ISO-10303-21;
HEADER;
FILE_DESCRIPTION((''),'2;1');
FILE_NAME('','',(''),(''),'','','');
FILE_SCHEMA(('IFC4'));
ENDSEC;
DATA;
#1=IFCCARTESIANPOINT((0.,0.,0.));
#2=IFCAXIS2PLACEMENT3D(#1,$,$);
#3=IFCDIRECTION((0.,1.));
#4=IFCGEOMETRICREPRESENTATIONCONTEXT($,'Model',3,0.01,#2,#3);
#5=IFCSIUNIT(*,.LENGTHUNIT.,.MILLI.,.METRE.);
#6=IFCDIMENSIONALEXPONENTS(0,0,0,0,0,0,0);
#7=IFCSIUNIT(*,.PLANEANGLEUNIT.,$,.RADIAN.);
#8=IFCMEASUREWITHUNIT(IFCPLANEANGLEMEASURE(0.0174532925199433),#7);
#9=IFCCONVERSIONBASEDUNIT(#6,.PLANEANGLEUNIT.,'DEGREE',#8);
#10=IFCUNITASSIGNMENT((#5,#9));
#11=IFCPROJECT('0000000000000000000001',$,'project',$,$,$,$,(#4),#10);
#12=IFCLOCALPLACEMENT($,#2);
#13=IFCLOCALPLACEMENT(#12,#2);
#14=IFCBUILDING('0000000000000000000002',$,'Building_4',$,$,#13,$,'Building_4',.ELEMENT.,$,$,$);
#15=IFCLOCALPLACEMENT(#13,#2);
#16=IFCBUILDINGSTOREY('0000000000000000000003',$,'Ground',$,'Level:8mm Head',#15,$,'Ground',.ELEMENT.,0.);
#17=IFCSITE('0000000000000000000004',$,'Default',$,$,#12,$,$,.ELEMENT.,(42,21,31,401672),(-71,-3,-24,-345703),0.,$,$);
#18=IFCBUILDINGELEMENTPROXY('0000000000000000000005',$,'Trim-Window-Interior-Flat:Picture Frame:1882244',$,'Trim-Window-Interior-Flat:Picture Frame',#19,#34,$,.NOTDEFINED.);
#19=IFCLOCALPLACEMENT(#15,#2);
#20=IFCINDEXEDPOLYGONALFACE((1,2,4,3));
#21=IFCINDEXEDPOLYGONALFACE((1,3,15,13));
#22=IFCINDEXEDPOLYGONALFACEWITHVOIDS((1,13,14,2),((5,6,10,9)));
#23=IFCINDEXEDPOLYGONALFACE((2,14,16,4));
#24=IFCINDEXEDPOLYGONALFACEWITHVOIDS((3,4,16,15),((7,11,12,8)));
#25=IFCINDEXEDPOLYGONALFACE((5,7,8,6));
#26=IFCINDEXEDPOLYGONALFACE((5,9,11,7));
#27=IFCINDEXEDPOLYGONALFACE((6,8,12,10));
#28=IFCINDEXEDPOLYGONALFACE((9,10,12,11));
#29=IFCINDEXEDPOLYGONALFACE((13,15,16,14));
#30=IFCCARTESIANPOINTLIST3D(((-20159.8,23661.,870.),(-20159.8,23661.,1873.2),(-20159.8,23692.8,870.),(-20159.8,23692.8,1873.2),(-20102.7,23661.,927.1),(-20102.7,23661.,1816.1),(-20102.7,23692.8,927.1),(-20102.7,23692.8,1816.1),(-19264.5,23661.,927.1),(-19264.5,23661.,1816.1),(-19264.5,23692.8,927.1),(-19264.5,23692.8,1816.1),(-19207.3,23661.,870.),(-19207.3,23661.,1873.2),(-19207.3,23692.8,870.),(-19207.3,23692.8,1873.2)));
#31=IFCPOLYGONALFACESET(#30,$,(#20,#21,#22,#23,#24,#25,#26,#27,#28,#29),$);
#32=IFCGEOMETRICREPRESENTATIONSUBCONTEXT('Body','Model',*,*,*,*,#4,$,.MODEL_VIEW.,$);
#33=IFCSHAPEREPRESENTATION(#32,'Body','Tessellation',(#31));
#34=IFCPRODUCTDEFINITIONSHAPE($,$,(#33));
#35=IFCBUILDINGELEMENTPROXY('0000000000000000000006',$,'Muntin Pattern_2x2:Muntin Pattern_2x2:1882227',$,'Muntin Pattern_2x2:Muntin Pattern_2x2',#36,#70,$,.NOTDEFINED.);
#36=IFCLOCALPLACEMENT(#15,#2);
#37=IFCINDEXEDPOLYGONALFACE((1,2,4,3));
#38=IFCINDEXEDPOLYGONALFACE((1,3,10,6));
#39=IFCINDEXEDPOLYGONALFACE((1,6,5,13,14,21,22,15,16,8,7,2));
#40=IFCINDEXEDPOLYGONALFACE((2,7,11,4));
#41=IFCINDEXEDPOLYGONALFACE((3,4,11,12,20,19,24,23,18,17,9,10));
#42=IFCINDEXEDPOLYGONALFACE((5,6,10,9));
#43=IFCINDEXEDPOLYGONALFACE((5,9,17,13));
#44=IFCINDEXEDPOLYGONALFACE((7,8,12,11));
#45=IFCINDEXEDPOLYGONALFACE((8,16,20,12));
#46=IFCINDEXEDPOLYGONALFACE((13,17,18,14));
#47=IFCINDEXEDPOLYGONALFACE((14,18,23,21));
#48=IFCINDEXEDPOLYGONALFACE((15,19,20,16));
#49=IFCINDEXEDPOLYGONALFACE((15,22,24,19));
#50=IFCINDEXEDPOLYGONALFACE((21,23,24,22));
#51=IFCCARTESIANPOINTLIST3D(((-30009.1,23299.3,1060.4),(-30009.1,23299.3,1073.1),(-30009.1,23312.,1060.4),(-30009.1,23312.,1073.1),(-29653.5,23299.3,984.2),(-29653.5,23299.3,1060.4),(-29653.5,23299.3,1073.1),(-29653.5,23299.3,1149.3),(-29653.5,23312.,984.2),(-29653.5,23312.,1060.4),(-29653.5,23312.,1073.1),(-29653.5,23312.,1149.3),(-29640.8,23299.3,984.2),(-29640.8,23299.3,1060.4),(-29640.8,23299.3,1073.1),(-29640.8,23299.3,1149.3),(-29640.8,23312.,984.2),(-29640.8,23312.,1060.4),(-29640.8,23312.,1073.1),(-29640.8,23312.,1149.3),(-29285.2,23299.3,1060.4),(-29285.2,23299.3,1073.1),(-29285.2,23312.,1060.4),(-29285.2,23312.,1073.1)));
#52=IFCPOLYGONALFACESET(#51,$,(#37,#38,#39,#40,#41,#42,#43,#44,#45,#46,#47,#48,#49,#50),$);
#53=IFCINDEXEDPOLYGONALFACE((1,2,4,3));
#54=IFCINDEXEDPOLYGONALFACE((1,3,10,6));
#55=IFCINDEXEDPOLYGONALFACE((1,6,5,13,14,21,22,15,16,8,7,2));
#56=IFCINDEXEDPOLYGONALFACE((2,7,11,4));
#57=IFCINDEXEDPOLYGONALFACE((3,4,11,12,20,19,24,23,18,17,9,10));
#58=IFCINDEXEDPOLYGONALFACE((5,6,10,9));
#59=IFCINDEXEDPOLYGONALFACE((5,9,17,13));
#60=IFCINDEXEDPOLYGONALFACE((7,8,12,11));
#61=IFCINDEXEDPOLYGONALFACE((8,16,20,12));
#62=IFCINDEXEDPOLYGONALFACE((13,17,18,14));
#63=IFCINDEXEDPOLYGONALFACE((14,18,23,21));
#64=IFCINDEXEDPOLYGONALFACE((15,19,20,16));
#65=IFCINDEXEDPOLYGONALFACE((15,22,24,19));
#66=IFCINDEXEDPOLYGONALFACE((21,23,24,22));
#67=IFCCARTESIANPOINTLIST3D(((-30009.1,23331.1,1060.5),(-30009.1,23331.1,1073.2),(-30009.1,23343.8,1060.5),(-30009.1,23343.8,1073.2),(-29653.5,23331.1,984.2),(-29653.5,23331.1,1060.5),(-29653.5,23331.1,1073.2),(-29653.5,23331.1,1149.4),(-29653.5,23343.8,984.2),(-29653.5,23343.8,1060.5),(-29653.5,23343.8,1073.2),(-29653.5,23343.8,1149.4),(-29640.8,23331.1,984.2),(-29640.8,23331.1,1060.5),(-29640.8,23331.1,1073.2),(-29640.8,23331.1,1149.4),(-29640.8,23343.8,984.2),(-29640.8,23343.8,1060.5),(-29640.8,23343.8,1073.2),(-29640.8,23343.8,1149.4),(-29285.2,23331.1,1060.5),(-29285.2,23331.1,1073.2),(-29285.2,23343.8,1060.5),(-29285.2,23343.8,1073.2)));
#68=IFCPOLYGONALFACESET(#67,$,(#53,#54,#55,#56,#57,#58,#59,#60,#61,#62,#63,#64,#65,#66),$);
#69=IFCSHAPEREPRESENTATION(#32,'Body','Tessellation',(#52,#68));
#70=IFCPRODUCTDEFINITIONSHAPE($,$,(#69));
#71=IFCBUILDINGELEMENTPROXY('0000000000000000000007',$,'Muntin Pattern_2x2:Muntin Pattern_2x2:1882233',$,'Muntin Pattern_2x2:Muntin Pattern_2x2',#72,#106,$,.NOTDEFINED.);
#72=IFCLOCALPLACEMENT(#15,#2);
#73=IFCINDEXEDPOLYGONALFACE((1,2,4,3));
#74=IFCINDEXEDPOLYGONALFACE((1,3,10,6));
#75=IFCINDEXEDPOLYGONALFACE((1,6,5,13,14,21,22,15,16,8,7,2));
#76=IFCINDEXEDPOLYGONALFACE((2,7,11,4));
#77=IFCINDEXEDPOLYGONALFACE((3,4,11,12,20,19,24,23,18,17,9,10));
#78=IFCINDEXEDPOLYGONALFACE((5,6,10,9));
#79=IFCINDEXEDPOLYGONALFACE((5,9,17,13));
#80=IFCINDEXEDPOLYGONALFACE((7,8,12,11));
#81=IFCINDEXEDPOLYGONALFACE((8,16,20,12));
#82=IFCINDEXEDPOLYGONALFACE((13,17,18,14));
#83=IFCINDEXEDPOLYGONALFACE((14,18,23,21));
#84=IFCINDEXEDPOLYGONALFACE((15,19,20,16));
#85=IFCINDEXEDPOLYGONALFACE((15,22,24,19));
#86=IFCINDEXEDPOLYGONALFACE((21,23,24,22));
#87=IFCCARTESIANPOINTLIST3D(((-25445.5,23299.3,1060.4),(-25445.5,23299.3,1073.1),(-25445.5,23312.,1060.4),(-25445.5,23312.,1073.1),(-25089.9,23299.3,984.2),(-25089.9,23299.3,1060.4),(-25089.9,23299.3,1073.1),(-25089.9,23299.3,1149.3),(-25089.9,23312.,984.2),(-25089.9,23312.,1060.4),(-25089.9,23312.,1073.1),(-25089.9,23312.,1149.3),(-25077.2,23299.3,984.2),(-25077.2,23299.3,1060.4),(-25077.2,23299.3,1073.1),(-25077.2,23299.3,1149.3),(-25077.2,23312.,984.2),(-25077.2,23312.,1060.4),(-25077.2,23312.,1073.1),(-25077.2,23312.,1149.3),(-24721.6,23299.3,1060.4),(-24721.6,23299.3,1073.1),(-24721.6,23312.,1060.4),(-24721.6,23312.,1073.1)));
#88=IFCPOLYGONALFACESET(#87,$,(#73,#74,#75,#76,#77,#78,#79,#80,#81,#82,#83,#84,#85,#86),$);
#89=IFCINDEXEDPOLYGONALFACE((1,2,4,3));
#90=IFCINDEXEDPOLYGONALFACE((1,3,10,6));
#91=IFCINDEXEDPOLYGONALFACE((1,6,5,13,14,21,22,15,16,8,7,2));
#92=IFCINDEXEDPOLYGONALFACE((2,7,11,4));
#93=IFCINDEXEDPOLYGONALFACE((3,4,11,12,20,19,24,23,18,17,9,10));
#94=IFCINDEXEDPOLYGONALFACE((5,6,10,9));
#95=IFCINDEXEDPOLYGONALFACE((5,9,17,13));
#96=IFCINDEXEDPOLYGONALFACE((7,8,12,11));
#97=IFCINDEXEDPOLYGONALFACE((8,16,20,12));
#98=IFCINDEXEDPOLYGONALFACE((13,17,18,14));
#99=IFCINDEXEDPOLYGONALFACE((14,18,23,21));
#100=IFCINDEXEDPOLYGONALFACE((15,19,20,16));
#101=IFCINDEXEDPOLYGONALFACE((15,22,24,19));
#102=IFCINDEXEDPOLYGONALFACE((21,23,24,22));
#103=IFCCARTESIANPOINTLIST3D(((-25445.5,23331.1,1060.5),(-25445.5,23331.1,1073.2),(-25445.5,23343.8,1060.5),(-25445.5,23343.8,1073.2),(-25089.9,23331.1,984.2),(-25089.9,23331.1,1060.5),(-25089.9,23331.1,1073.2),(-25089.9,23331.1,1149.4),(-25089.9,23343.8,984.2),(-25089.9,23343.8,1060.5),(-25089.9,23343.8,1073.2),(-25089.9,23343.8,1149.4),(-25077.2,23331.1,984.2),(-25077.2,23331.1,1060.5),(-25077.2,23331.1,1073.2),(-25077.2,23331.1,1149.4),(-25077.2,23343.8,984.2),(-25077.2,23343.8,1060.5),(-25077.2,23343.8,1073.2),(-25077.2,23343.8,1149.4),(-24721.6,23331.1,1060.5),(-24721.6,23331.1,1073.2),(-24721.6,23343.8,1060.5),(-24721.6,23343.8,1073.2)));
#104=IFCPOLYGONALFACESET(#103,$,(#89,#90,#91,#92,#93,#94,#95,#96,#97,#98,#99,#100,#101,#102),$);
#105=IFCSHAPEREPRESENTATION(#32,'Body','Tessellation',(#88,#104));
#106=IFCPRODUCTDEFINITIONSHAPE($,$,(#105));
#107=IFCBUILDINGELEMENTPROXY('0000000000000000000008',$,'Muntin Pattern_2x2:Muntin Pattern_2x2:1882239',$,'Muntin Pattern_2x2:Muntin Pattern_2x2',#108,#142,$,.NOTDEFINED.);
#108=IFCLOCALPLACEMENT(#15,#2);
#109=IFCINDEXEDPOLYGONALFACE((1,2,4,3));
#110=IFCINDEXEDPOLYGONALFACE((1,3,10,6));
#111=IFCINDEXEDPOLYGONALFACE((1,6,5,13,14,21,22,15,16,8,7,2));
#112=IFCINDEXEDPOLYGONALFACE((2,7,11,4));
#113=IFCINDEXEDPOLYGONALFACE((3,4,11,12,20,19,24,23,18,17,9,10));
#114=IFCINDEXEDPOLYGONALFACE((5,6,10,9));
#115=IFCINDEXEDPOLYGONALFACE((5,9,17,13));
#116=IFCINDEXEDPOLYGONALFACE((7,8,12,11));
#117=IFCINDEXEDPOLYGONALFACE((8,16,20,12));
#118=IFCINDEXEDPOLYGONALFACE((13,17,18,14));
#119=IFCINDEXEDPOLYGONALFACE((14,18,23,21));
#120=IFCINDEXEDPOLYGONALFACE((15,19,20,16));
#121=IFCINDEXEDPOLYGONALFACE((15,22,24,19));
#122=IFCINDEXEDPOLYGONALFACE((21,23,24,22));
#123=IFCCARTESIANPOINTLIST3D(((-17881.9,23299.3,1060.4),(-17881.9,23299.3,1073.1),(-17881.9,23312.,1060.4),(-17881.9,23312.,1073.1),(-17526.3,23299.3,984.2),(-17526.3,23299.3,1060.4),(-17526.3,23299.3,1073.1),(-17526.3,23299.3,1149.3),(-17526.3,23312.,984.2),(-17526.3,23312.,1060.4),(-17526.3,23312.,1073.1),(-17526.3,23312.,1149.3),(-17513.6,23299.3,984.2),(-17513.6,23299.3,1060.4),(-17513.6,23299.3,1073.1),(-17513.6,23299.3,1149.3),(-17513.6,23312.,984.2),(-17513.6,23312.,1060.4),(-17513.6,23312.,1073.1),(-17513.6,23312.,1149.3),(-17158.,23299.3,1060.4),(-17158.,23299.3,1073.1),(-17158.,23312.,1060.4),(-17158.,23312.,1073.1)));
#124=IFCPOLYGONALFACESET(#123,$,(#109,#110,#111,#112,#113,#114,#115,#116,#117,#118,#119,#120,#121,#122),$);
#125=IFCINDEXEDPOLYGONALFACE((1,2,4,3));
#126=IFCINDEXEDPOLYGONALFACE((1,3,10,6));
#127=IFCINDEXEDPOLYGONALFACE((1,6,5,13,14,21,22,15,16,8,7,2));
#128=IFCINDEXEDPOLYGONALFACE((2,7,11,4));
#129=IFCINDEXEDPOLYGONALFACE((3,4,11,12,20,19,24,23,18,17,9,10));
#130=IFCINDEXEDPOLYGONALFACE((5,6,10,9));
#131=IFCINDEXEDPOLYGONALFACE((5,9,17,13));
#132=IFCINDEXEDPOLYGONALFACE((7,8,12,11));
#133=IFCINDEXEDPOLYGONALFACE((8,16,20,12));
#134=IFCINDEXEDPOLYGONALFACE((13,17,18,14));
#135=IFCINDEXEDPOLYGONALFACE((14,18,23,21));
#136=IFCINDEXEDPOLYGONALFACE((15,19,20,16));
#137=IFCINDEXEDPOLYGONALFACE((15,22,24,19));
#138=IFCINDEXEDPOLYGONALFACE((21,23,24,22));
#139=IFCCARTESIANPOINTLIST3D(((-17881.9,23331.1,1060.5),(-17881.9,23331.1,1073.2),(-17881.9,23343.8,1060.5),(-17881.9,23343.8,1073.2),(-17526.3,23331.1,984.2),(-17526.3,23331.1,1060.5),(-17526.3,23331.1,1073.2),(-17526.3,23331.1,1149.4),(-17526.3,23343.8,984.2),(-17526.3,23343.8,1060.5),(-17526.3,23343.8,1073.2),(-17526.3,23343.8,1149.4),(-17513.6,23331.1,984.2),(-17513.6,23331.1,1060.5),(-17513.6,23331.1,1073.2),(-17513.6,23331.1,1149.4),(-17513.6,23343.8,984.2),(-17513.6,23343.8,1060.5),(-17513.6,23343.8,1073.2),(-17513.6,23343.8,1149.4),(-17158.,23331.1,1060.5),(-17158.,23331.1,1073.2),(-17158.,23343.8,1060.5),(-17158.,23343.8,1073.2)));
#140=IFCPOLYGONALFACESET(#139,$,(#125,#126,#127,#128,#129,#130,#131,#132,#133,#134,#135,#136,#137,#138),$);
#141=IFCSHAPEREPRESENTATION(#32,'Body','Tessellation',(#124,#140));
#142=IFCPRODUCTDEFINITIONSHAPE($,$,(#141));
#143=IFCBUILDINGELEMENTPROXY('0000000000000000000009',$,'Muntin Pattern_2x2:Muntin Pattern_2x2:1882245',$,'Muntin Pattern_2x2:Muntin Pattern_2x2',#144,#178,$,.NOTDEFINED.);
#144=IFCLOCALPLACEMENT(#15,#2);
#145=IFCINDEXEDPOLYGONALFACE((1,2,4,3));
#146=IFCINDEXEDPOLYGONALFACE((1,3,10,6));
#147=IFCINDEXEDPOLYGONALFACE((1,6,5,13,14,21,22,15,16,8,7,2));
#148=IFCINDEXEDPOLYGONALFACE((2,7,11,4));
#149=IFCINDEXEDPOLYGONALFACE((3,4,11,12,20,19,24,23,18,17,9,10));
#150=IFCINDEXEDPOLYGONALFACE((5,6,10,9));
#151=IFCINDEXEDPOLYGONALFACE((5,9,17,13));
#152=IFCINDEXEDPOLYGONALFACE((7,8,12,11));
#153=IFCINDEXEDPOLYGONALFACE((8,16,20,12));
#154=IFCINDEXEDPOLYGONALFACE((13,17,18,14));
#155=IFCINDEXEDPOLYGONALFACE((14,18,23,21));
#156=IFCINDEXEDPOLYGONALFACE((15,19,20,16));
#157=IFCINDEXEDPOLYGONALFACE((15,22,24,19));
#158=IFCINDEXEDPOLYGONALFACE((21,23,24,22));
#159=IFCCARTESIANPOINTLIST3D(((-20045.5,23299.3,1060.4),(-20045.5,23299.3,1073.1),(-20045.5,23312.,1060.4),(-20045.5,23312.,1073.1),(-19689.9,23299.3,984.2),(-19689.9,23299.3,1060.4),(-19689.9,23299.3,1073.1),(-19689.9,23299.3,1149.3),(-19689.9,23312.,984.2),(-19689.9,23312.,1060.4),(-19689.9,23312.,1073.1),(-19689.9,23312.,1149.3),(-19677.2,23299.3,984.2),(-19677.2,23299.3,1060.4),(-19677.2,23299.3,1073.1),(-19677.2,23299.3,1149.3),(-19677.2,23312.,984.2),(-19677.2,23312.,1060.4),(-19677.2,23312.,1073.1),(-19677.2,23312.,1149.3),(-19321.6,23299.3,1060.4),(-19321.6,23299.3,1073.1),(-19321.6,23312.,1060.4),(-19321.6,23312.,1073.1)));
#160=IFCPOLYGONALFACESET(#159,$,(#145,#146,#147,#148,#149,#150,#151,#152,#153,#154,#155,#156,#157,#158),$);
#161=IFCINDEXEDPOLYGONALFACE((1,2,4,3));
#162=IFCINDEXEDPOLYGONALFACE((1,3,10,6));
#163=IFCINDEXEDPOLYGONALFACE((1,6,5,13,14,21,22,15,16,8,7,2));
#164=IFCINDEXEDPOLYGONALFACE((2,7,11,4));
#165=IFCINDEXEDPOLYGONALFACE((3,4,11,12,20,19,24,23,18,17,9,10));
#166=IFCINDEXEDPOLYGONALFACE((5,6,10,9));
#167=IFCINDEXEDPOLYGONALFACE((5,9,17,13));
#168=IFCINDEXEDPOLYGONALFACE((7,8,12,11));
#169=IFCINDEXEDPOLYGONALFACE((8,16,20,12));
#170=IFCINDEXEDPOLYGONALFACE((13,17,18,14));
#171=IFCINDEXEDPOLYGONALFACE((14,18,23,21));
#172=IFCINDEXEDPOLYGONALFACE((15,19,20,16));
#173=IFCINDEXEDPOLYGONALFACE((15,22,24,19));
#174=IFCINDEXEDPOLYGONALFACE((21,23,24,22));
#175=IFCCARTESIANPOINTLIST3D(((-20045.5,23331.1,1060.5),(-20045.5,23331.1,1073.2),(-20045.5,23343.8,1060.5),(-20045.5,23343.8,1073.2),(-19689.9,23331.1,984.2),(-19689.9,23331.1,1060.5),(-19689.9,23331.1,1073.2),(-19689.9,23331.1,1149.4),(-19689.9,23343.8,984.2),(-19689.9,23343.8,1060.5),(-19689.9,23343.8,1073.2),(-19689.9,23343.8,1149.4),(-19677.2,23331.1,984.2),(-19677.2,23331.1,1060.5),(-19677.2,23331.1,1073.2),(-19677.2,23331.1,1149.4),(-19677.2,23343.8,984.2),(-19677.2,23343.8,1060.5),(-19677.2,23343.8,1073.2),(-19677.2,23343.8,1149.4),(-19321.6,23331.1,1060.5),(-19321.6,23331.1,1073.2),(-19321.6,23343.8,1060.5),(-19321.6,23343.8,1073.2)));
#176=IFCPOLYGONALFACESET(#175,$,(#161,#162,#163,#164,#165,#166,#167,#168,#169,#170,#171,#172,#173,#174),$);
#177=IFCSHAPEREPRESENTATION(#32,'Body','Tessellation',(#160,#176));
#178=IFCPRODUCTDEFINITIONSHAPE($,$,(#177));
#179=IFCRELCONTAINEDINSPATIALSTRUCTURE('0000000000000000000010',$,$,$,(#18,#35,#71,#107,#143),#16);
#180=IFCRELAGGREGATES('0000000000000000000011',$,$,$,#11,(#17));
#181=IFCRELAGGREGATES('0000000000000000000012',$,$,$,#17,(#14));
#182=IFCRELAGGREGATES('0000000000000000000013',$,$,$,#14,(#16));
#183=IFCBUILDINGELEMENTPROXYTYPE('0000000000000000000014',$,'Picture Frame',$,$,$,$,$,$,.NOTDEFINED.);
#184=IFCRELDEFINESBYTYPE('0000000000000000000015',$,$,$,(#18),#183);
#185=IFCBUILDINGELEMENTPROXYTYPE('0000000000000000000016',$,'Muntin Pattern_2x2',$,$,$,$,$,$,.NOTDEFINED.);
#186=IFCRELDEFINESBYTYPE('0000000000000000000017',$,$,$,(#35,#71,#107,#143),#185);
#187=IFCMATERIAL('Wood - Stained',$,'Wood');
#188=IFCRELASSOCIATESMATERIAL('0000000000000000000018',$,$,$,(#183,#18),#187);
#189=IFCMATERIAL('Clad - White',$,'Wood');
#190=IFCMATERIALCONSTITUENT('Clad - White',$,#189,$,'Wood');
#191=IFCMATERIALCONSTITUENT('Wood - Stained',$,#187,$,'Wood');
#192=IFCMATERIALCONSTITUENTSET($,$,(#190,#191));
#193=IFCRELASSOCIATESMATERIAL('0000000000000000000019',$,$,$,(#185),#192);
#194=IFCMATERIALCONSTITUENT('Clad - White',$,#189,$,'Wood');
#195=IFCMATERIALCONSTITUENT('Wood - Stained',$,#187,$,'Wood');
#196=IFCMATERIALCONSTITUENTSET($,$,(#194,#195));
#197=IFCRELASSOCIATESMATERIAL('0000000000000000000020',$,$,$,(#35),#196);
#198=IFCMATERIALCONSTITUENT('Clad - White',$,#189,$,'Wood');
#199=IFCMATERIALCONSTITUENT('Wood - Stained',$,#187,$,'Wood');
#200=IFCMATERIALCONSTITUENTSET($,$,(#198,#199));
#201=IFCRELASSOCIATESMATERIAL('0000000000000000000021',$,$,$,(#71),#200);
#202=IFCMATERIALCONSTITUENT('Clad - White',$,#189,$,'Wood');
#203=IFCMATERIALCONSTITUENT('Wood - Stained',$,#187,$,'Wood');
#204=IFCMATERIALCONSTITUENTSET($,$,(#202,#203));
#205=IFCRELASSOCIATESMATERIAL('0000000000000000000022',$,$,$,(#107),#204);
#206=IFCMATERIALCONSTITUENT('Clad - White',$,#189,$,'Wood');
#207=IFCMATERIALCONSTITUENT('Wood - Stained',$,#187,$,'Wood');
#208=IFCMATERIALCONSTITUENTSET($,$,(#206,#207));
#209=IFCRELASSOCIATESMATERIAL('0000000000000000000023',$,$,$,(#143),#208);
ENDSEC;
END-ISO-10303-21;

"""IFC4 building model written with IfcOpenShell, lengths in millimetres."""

from ifc_helpers import new_model, entity, si_unit, converted_unit, direction, frame, origin, place, context, subcontext, project, spatial, indexed_curve, outline, extrude, source, transform, mapped, material, constituent, constituent_set, type_object, type_shapes, element, save


model = new_model("IFC4")

# Units and contexts
model_context = context("Model", 3, precision=0.01, world=origin(), true_north=direction((0.0, 1.0)))
body_context = subcontext(model_context, "Body", "Model", "MODEL_VIEW")
ifc_project = project(units=[si_unit("LENGTHUNIT", "METRE", prefix="MILLI"), converted_unit("PLANEANGLEUNIT", "DEGREE", entity("IfcPlaneAngleMeasure", 0.0174532925199433), si_unit("PLANEANGLEUNIT", "RADIAN"), dimensions=[0, 0, 0, 0, 0, 0, 0])], contexts=[model_context])

# Site, building, storey
site_placement = place(None, origin())
site = spatial("IfcSite", under=ifc_project, at=site_placement, Name="Default", CompositionType="ELEMENT", RefLatitude=(42, 21, 31, 401672), RefLongitude=(-71, -3, -24, -345703), RefElevation=0.0)
building_placement = place(site_placement, origin())
building = spatial("IfcBuilding", under=site, at=building_placement, Name="Building_4", LongName="Building_4", CompositionType="ELEMENT")
storey_placement = place(building_placement, origin())
storey = spatial("IfcBuildingStorey", under=building, at=storey_placement, Name="Ground", ObjectType="Level:8mm Head", LongName="Ground", CompositionType="ELEMENT", Elevation=0.0)

# Shared definitions
ifc_material_1 = material(Name="Clad - White", Category="Wood")
ifc_material_2 = material(Name="Wood - Stained", Category="Wood")

# Building element proxies
building_element_proxy_type_1 = type_object("IfcBuildingElementProxyType", Name="Picture Frame", PredefinedType="NOTDEFINED", material=ifc_material_2)
shared_shape_1 = source(origin(), body_context, "Body", "SweptSolid", [
    extrude(outline(indexed_curve([(-476.2, -501.6), (476.2, -501.6), (476.2, 501.6), (-476.2, 501.6), (-476.2, -501.6)], self_intersect=False), holes=[indexed_curve([(-419.1, -444.5), (-419.1, 444.5), (419.1, 444.5), (419.1, -444.5), (-419.1, -444.5)], self_intersect=False)]), frame((0.0, -457.2, 0.0), z_axis=(0.0, 0.0, 1.0), x_axis=(-1.0, 0.0, 0.0)), (0.0, 0.0, 1.0), 31.8),
])
type_shapes(building_element_proxy_type_1, [shared_shape_1])
for number, where, z_axis, x_axis, name in (
    (1, (-19683.6, 23661.0, 1828.8), (0.0, 1.0, 0.0), (-1.0, 0.0, 0.0), "Trim-Window-Interior-Flat:Picture Frame:1882244"),
):
    element("IfcBuildingElementProxy", number, at=place(storey_placement, frame(where, z_axis=z_axis, x_axis=x_axis)), inside=storey, type_object=building_element_proxy_type_1, material=ifc_material_2, Name=name, ObjectType="Trim-Window-Interior-Flat:Picture Frame", PredefinedType="NOTDEFINED", context=body_context, shape_type="MappedRepresentation", body=[
        mapped(shared_shape_1, transform((0.0, 0.0, 0.0), scale=1.0)),
    ])
ifc_constituent_1 = constituent(ifc_material_1, Name="Clad - White", Category="Wood")
ifc_constituent_2 = constituent(ifc_material_2, Name="Wood - Stained", Category="Wood")
ifc_constituent_set_1 = constituent_set(constituents=[ifc_constituent_1, ifc_constituent_2])
ifc_constituent_3 = constituent(ifc_material_1, Name="Clad - White", Category="Wood")
ifc_constituent_4 = constituent(ifc_material_2, Name="Wood - Stained", Category="Wood")
ifc_constituent_set_2 = constituent_set(constituents=[ifc_constituent_3, ifc_constituent_4])
building_element_proxy_type_2 = type_object("IfcBuildingElementProxyType", Name="Muntin Pattern_2x2", PredefinedType="NOTDEFINED", material=ifc_constituent_set_2)
shared_shape_2 = source(origin(), body_context, "Body", "SweptSolid", [
    extrude(outline(indexed_curve([(6.4, -6.4), (82.5, -6.4), (82.5, 6.3), (6.4, 6.3), (6.4, 362.0), (-6.3, 362.0), (-6.3, 6.3), (-82.6, 6.3), (-82.6, -6.4), (-6.3, -6.4), (-6.3, -361.9), (6.4, -361.9), (6.4, -6.4)], self_intersect=False)), frame((0.0, -22.2, 82.5), z_axis=(0.0, 1.0, 0.0), x_axis=(0.0, 0.0, 1.0)), (0.0, 0.0, 1.0), 12.7),
    extrude(outline(indexed_curve([(6.4, -6.4), (82.6, -6.4), (82.6, 6.3), (6.4, 6.3), (6.4, 362.0), (-6.3, 362.0), (-6.3, 6.3), (-82.6, 6.3), (-82.6, -6.4), (-6.3, -6.4), (-6.3, -361.9), (6.4, -361.9), (6.4, -6.4)], self_intersect=False)), frame((0.0, 9.5, 82.6), z_axis=(0.0, 1.0, 0.0), x_axis=(0.0, 0.0, 1.0)), (0.0, 0.0, 1.0), 12.7),
])
type_shapes(building_element_proxy_type_2, [shared_shape_2])
proxy_1_placement = place(storey_placement, frame((-29647.2, 23321.5, 984.2)))
element("IfcBuildingElementProxy", 2, at=proxy_1_placement, inside=storey, type_object=building_element_proxy_type_2, material=ifc_constituent_set_1, Name="Muntin Pattern_2x2:Muntin Pattern_2x2:1882227", ObjectType="Muntin Pattern_2x2:Muntin Pattern_2x2", PredefinedType="NOTDEFINED", context=body_context, shape_type="MappedRepresentation", body=[
    mapped(shared_shape_2, transform((0.0, 0.0, 0.0), scale=1.0)),
])
ifc_constituent_5 = constituent(ifc_material_1, Name="Clad - White", Category="Wood")
ifc_constituent_6 = constituent(ifc_material_2, Name="Wood - Stained", Category="Wood")
ifc_constituent_set_3 = constituent_set(constituents=[ifc_constituent_5, ifc_constituent_6])
proxy_2_placement = place(storey_placement, frame((-25083.6, 23321.5, 984.2)))
element("IfcBuildingElementProxy", 3, at=proxy_2_placement, inside=storey, type_object=building_element_proxy_type_2, material=ifc_constituent_set_3, Name="Muntin Pattern_2x2:Muntin Pattern_2x2:1882233", ObjectType="Muntin Pattern_2x2:Muntin Pattern_2x2", PredefinedType="NOTDEFINED", context=body_context, shape_type="MappedRepresentation", body=[
    mapped(shared_shape_2, transform((0.0, 0.0, 0.0), scale=1.0)),
])
ifc_constituent_7 = constituent(ifc_material_1, Name="Clad - White", Category="Wood")
ifc_constituent_8 = constituent(ifc_material_2, Name="Wood - Stained", Category="Wood")
ifc_constituent_set_4 = constituent_set(constituents=[ifc_constituent_7, ifc_constituent_8])
proxy_3_placement = place(storey_placement, frame((-17520.0, 23321.5, 984.2)))
element("IfcBuildingElementProxy", 4, at=proxy_3_placement, inside=storey, type_object=building_element_proxy_type_2, material=ifc_constituent_set_4, Name="Muntin Pattern_2x2:Muntin Pattern_2x2:1882239", ObjectType="Muntin Pattern_2x2:Muntin Pattern_2x2", PredefinedType="NOTDEFINED", context=body_context, shape_type="MappedRepresentation", body=[
    mapped(shared_shape_2, transform((0.0, 0.0, 0.0), scale=1.0)),
])
ifc_constituent_9 = constituent(ifc_material_1, Name="Clad - White", Category="Wood")
ifc_constituent_10 = constituent(ifc_material_2, Name="Wood - Stained", Category="Wood")
ifc_constituent_set_5 = constituent_set(constituents=[ifc_constituent_9, ifc_constituent_10])
proxy_4_placement = place(storey_placement, frame((-19683.6, 23321.5, 984.2)))
element("IfcBuildingElementProxy", 5, at=proxy_4_placement, inside=storey, type_object=building_element_proxy_type_2, material=ifc_constituent_set_5, Name="Muntin Pattern_2x2:Muntin Pattern_2x2:1882245", ObjectType="Muntin Pattern_2x2:Muntin Pattern_2x2", PredefinedType="NOTDEFINED", context=body_context, shape_type="MappedRepresentation", body=[
    mapped(shared_shape_2, transform((0.0, 0.0, 0.0), scale=1.0)),
])

save(model, "model.ifc")
